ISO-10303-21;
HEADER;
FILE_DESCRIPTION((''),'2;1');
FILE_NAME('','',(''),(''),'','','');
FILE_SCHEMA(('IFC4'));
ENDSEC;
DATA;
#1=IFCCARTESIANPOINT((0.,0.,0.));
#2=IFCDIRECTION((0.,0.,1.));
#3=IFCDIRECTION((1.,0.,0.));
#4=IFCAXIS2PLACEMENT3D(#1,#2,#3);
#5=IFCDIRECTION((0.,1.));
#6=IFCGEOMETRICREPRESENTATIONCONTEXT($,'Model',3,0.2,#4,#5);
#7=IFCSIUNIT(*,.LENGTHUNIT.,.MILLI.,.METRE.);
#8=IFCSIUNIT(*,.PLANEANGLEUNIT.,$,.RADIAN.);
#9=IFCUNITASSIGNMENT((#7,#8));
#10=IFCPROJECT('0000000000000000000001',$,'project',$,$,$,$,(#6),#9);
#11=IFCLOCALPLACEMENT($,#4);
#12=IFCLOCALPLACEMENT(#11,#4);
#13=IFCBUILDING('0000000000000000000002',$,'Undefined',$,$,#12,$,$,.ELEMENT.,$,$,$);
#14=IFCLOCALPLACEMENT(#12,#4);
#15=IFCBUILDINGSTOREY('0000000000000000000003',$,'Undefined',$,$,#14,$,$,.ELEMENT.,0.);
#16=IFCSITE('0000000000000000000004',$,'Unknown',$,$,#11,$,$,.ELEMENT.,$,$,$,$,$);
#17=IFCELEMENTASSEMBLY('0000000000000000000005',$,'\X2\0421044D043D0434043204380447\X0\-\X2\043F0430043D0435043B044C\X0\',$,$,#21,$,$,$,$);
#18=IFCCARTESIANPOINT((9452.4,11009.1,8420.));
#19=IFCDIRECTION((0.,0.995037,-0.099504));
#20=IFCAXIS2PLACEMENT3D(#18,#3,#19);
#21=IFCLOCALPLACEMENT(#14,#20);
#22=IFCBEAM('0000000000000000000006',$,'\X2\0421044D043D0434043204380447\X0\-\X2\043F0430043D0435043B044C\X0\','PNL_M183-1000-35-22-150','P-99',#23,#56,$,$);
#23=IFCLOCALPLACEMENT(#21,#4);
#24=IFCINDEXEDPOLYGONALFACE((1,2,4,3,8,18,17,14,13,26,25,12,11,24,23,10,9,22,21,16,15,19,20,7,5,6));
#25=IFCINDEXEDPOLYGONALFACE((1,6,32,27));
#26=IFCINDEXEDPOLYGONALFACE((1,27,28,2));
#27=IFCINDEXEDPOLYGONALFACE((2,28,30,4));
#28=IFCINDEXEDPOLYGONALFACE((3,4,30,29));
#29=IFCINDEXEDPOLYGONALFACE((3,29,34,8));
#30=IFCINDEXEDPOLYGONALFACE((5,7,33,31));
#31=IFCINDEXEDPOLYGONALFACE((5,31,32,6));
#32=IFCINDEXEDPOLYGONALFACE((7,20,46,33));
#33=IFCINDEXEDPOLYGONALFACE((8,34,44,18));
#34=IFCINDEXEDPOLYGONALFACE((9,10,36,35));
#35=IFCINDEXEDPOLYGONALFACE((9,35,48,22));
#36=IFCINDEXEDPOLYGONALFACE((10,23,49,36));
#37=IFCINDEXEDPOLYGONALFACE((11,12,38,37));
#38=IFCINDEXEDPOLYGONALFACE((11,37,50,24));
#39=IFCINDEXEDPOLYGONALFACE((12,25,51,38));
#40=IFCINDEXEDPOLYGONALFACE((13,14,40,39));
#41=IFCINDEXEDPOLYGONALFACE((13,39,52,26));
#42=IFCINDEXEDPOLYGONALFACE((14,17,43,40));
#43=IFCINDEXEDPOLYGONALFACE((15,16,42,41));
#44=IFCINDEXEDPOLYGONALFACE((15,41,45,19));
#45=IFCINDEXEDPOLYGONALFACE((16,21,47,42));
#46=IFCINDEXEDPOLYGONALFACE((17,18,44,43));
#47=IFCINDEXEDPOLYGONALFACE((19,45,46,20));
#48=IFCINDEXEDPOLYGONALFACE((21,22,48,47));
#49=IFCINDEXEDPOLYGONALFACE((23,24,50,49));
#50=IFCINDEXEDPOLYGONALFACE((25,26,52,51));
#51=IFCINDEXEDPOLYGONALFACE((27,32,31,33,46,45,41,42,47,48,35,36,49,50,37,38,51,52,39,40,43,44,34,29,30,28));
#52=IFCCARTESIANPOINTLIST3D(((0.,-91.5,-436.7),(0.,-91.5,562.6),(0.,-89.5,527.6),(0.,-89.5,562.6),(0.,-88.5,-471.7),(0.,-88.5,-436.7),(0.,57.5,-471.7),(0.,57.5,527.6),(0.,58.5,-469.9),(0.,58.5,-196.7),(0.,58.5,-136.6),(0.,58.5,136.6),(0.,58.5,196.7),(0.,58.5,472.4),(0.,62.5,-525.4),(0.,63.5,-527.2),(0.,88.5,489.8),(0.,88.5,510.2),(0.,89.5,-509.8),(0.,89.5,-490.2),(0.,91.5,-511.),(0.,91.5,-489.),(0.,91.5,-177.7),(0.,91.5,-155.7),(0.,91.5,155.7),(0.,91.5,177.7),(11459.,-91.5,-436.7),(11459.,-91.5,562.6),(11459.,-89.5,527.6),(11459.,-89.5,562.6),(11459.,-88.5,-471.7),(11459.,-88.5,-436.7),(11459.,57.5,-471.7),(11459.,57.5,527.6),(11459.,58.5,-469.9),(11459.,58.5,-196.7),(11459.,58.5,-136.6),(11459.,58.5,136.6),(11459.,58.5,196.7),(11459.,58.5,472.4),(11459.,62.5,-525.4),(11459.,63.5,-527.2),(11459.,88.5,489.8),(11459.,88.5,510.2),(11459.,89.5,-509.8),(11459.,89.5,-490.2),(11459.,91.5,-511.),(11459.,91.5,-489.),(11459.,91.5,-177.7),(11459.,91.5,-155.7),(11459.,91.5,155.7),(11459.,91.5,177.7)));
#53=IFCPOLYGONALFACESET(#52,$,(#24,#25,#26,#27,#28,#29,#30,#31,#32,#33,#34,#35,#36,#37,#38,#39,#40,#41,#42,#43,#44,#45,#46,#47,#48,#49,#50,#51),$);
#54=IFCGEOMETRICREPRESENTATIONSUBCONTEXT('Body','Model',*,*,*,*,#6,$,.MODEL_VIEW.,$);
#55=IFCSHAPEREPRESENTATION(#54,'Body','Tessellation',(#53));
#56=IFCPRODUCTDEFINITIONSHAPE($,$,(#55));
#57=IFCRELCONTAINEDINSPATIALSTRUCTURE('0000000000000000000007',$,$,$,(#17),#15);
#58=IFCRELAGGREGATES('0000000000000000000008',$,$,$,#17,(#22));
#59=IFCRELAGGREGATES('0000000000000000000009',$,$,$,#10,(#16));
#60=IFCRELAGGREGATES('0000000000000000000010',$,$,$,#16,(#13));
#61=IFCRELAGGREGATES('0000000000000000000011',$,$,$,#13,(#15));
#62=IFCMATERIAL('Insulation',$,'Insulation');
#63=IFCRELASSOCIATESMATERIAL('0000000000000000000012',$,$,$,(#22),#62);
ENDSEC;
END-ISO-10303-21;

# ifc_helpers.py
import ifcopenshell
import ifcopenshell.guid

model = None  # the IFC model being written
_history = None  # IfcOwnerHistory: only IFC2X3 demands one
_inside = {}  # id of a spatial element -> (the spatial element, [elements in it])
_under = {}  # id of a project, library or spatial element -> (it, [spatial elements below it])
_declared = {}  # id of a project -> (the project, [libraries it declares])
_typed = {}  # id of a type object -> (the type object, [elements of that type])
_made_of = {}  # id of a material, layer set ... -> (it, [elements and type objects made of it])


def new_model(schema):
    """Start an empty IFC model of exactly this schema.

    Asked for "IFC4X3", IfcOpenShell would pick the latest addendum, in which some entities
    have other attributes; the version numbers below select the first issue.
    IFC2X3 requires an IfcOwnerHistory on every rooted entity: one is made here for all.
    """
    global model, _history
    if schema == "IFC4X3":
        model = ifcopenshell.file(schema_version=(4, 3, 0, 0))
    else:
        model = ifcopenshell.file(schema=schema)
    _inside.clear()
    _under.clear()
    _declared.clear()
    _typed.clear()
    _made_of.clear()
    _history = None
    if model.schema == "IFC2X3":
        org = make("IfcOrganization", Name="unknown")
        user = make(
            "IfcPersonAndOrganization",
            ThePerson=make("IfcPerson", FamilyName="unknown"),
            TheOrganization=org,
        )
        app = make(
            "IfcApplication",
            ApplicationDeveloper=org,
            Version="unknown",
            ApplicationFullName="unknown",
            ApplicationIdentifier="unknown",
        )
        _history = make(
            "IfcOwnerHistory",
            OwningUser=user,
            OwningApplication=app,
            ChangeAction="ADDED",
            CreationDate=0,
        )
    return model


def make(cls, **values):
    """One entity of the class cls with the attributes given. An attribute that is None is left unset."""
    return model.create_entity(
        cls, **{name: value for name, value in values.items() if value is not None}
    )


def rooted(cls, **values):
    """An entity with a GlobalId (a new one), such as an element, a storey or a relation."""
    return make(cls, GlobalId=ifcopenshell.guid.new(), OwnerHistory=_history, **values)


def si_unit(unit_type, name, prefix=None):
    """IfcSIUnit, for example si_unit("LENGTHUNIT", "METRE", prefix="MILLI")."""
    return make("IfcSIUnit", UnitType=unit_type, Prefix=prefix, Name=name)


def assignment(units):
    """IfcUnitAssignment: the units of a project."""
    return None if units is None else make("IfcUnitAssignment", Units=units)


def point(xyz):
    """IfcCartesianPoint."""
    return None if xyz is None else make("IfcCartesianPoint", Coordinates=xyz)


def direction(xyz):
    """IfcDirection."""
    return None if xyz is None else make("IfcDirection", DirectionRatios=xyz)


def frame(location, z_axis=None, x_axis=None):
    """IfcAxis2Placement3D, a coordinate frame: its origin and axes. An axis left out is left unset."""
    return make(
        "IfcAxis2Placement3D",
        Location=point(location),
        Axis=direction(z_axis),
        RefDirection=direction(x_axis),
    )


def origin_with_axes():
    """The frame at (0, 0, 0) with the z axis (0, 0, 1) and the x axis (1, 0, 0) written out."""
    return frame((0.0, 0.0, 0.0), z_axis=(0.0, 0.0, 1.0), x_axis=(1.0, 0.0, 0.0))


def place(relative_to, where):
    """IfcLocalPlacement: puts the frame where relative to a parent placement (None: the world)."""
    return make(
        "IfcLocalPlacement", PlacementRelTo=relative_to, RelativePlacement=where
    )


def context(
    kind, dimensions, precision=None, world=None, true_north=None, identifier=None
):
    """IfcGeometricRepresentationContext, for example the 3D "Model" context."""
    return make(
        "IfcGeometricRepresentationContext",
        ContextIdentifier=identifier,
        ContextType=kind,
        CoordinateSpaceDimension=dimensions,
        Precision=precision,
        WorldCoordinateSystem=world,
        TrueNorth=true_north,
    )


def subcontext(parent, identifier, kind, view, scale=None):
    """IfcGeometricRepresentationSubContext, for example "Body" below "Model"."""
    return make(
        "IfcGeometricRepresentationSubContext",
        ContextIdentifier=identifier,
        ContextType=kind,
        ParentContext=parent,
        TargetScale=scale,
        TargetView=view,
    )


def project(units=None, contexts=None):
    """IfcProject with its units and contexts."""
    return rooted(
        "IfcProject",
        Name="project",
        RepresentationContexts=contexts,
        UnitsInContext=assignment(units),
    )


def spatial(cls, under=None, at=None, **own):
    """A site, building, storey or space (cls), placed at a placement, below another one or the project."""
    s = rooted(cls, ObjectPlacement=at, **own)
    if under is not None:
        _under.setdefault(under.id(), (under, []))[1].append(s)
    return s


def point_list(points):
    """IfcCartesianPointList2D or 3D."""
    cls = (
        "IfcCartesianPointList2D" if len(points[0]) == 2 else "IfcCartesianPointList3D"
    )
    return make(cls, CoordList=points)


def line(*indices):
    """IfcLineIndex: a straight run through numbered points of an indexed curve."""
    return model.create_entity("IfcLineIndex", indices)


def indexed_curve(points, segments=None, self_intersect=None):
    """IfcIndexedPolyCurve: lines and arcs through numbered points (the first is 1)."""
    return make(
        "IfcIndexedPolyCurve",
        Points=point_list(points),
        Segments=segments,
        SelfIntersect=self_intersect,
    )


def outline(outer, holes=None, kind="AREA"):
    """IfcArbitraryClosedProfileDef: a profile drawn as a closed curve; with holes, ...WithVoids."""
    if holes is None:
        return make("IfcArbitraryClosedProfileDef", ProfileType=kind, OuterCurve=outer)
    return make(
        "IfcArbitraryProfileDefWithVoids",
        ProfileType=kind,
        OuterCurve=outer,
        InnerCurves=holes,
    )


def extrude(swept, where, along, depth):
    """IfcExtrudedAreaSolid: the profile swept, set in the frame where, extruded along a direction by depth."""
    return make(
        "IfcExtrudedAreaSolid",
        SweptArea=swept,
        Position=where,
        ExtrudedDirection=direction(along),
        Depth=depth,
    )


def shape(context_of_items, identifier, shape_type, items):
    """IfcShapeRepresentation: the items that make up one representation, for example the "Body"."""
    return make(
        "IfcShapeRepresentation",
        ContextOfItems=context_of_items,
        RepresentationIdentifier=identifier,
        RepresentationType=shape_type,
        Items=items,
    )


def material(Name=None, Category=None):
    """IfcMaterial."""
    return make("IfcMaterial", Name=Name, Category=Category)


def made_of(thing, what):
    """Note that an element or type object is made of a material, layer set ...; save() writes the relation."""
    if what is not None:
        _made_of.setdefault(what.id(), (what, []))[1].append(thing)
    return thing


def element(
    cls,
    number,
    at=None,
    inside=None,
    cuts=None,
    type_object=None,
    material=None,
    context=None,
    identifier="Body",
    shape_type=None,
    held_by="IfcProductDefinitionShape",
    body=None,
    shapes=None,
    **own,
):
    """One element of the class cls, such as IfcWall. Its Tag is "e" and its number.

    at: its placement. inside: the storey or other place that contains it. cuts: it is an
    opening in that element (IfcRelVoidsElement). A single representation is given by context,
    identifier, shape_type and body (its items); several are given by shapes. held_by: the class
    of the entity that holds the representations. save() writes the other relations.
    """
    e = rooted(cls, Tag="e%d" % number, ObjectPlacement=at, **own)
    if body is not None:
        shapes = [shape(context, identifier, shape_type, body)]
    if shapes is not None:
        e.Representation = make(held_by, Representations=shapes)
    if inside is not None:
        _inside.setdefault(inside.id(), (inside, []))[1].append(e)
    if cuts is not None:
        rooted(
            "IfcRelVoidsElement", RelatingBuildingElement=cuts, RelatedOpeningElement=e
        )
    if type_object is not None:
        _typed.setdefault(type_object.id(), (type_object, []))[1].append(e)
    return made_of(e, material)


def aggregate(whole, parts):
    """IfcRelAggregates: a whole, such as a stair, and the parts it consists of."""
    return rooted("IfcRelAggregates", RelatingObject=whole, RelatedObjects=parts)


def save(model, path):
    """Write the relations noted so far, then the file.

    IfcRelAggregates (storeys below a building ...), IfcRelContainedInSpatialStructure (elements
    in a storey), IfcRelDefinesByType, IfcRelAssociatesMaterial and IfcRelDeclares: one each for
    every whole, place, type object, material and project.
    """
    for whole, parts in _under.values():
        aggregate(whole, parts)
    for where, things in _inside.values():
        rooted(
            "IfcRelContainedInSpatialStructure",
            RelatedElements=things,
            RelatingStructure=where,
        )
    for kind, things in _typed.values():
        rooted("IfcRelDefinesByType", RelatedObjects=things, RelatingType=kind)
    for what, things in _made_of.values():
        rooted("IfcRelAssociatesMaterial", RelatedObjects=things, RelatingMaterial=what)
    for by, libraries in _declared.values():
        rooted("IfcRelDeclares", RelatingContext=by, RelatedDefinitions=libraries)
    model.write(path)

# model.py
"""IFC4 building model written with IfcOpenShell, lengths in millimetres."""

from ifc_helpers import new_model, si_unit, direction, frame, origin_with_axes, place, context, subcontext, project, spatial, line, indexed_curve, outline, extrude, material, element, aggregate, save


model = new_model("IFC4")

# Units and contexts
model_context = context("Model", 3, precision=0.2, world=origin_with_axes(), true_north=direction((0.0, 1.0)))
body_context = subcontext(model_context, "Body", "Model", "MODEL_VIEW")
ifc_project = project(units=[si_unit("LENGTHUNIT", "METRE", prefix="MILLI"), si_unit("PLANEANGLEUNIT", "RADIAN")], contexts=[model_context])

# Site, building, storey
site_placement = place(None, origin_with_axes())
site = spatial("IfcSite", under=ifc_project, at=site_placement, Name="Unknown", CompositionType="ELEMENT")
building_placement = place(site_placement, origin_with_axes())
building = spatial("IfcBuilding", under=site, at=building_placement, Name="Undefined", CompositionType="ELEMENT")
storey_placement = place(building_placement, origin_with_axes())
storey = spatial("IfcBuildingStorey", under=building, at=storey_placement, Name="Undefined", CompositionType="ELEMENT", Elevation=0.0)

# Element assembly, beam
assembly_1_placement = place(storey_placement, frame((9452.4, 11009.1, 8420.0), z_axis=(1.0, 0.0, 0.0), x_axis=(0.0, 0.995037, -0.099504)))
assembly_1 = element("IfcElementAssembly", 1, at=assembly_1_placement, inside=storey, Name="Сэндвич-панель")
ifc_material_1 = material(Name="Insulation", Category="Insulation")
beam_1_placement = place(assembly_1_placement, origin_with_axes())
beam_1 = element("IfcBeam", 2, at=beam_1_placement, material=ifc_material_1, Name="Сэндвич-панель", Description="PNL_M183-1000-35-22-150", ObjectType="P-99", context=body_context, shape_type="SolidModel", body=[
    extrude(outline(indexed_curve([(-509.8, 89.5), (-490.2, 89.5), (-471.7, 57.5), (-471.7, -88.5), (-436.7, -88.5), (-436.7, -91.5), (562.6, -91.5), (562.6, -89.5), (527.6, -89.5), (527.6, 57.5), (510.2, 88.5), (489.8, 88.5), (472.4, 58.5), (196.7, 58.5), (177.7, 91.5), (155.7, 91.5), (136.6, 58.5), (-136.6, 58.5), (-155.7, 91.5), (-177.7, 91.5), (-196.7, 58.5), (-469.9, 58.5), (-489.0, 91.5), (-511.0, 91.5), (-527.2, 63.5), (-525.4, 62.5)], segments=[line(1, 2, 3, 4, 5, 6, 7, 8, 9, 10, 11, 12, 13, 14, 15, 16, 17, 18, 19, 20, 21, 22, 23, 24, 25, 26, 1)])), frame((0.0, 0.0, 0.0), z_axis=(-1.0, 0.0, 0.0), x_axis=(0.0, 0.0, 1.0)), (0.0, 0.0, -1.0), 11459.0),
])
aggregate(assembly_1, [beam_1])

save(model, "model.ifc")
